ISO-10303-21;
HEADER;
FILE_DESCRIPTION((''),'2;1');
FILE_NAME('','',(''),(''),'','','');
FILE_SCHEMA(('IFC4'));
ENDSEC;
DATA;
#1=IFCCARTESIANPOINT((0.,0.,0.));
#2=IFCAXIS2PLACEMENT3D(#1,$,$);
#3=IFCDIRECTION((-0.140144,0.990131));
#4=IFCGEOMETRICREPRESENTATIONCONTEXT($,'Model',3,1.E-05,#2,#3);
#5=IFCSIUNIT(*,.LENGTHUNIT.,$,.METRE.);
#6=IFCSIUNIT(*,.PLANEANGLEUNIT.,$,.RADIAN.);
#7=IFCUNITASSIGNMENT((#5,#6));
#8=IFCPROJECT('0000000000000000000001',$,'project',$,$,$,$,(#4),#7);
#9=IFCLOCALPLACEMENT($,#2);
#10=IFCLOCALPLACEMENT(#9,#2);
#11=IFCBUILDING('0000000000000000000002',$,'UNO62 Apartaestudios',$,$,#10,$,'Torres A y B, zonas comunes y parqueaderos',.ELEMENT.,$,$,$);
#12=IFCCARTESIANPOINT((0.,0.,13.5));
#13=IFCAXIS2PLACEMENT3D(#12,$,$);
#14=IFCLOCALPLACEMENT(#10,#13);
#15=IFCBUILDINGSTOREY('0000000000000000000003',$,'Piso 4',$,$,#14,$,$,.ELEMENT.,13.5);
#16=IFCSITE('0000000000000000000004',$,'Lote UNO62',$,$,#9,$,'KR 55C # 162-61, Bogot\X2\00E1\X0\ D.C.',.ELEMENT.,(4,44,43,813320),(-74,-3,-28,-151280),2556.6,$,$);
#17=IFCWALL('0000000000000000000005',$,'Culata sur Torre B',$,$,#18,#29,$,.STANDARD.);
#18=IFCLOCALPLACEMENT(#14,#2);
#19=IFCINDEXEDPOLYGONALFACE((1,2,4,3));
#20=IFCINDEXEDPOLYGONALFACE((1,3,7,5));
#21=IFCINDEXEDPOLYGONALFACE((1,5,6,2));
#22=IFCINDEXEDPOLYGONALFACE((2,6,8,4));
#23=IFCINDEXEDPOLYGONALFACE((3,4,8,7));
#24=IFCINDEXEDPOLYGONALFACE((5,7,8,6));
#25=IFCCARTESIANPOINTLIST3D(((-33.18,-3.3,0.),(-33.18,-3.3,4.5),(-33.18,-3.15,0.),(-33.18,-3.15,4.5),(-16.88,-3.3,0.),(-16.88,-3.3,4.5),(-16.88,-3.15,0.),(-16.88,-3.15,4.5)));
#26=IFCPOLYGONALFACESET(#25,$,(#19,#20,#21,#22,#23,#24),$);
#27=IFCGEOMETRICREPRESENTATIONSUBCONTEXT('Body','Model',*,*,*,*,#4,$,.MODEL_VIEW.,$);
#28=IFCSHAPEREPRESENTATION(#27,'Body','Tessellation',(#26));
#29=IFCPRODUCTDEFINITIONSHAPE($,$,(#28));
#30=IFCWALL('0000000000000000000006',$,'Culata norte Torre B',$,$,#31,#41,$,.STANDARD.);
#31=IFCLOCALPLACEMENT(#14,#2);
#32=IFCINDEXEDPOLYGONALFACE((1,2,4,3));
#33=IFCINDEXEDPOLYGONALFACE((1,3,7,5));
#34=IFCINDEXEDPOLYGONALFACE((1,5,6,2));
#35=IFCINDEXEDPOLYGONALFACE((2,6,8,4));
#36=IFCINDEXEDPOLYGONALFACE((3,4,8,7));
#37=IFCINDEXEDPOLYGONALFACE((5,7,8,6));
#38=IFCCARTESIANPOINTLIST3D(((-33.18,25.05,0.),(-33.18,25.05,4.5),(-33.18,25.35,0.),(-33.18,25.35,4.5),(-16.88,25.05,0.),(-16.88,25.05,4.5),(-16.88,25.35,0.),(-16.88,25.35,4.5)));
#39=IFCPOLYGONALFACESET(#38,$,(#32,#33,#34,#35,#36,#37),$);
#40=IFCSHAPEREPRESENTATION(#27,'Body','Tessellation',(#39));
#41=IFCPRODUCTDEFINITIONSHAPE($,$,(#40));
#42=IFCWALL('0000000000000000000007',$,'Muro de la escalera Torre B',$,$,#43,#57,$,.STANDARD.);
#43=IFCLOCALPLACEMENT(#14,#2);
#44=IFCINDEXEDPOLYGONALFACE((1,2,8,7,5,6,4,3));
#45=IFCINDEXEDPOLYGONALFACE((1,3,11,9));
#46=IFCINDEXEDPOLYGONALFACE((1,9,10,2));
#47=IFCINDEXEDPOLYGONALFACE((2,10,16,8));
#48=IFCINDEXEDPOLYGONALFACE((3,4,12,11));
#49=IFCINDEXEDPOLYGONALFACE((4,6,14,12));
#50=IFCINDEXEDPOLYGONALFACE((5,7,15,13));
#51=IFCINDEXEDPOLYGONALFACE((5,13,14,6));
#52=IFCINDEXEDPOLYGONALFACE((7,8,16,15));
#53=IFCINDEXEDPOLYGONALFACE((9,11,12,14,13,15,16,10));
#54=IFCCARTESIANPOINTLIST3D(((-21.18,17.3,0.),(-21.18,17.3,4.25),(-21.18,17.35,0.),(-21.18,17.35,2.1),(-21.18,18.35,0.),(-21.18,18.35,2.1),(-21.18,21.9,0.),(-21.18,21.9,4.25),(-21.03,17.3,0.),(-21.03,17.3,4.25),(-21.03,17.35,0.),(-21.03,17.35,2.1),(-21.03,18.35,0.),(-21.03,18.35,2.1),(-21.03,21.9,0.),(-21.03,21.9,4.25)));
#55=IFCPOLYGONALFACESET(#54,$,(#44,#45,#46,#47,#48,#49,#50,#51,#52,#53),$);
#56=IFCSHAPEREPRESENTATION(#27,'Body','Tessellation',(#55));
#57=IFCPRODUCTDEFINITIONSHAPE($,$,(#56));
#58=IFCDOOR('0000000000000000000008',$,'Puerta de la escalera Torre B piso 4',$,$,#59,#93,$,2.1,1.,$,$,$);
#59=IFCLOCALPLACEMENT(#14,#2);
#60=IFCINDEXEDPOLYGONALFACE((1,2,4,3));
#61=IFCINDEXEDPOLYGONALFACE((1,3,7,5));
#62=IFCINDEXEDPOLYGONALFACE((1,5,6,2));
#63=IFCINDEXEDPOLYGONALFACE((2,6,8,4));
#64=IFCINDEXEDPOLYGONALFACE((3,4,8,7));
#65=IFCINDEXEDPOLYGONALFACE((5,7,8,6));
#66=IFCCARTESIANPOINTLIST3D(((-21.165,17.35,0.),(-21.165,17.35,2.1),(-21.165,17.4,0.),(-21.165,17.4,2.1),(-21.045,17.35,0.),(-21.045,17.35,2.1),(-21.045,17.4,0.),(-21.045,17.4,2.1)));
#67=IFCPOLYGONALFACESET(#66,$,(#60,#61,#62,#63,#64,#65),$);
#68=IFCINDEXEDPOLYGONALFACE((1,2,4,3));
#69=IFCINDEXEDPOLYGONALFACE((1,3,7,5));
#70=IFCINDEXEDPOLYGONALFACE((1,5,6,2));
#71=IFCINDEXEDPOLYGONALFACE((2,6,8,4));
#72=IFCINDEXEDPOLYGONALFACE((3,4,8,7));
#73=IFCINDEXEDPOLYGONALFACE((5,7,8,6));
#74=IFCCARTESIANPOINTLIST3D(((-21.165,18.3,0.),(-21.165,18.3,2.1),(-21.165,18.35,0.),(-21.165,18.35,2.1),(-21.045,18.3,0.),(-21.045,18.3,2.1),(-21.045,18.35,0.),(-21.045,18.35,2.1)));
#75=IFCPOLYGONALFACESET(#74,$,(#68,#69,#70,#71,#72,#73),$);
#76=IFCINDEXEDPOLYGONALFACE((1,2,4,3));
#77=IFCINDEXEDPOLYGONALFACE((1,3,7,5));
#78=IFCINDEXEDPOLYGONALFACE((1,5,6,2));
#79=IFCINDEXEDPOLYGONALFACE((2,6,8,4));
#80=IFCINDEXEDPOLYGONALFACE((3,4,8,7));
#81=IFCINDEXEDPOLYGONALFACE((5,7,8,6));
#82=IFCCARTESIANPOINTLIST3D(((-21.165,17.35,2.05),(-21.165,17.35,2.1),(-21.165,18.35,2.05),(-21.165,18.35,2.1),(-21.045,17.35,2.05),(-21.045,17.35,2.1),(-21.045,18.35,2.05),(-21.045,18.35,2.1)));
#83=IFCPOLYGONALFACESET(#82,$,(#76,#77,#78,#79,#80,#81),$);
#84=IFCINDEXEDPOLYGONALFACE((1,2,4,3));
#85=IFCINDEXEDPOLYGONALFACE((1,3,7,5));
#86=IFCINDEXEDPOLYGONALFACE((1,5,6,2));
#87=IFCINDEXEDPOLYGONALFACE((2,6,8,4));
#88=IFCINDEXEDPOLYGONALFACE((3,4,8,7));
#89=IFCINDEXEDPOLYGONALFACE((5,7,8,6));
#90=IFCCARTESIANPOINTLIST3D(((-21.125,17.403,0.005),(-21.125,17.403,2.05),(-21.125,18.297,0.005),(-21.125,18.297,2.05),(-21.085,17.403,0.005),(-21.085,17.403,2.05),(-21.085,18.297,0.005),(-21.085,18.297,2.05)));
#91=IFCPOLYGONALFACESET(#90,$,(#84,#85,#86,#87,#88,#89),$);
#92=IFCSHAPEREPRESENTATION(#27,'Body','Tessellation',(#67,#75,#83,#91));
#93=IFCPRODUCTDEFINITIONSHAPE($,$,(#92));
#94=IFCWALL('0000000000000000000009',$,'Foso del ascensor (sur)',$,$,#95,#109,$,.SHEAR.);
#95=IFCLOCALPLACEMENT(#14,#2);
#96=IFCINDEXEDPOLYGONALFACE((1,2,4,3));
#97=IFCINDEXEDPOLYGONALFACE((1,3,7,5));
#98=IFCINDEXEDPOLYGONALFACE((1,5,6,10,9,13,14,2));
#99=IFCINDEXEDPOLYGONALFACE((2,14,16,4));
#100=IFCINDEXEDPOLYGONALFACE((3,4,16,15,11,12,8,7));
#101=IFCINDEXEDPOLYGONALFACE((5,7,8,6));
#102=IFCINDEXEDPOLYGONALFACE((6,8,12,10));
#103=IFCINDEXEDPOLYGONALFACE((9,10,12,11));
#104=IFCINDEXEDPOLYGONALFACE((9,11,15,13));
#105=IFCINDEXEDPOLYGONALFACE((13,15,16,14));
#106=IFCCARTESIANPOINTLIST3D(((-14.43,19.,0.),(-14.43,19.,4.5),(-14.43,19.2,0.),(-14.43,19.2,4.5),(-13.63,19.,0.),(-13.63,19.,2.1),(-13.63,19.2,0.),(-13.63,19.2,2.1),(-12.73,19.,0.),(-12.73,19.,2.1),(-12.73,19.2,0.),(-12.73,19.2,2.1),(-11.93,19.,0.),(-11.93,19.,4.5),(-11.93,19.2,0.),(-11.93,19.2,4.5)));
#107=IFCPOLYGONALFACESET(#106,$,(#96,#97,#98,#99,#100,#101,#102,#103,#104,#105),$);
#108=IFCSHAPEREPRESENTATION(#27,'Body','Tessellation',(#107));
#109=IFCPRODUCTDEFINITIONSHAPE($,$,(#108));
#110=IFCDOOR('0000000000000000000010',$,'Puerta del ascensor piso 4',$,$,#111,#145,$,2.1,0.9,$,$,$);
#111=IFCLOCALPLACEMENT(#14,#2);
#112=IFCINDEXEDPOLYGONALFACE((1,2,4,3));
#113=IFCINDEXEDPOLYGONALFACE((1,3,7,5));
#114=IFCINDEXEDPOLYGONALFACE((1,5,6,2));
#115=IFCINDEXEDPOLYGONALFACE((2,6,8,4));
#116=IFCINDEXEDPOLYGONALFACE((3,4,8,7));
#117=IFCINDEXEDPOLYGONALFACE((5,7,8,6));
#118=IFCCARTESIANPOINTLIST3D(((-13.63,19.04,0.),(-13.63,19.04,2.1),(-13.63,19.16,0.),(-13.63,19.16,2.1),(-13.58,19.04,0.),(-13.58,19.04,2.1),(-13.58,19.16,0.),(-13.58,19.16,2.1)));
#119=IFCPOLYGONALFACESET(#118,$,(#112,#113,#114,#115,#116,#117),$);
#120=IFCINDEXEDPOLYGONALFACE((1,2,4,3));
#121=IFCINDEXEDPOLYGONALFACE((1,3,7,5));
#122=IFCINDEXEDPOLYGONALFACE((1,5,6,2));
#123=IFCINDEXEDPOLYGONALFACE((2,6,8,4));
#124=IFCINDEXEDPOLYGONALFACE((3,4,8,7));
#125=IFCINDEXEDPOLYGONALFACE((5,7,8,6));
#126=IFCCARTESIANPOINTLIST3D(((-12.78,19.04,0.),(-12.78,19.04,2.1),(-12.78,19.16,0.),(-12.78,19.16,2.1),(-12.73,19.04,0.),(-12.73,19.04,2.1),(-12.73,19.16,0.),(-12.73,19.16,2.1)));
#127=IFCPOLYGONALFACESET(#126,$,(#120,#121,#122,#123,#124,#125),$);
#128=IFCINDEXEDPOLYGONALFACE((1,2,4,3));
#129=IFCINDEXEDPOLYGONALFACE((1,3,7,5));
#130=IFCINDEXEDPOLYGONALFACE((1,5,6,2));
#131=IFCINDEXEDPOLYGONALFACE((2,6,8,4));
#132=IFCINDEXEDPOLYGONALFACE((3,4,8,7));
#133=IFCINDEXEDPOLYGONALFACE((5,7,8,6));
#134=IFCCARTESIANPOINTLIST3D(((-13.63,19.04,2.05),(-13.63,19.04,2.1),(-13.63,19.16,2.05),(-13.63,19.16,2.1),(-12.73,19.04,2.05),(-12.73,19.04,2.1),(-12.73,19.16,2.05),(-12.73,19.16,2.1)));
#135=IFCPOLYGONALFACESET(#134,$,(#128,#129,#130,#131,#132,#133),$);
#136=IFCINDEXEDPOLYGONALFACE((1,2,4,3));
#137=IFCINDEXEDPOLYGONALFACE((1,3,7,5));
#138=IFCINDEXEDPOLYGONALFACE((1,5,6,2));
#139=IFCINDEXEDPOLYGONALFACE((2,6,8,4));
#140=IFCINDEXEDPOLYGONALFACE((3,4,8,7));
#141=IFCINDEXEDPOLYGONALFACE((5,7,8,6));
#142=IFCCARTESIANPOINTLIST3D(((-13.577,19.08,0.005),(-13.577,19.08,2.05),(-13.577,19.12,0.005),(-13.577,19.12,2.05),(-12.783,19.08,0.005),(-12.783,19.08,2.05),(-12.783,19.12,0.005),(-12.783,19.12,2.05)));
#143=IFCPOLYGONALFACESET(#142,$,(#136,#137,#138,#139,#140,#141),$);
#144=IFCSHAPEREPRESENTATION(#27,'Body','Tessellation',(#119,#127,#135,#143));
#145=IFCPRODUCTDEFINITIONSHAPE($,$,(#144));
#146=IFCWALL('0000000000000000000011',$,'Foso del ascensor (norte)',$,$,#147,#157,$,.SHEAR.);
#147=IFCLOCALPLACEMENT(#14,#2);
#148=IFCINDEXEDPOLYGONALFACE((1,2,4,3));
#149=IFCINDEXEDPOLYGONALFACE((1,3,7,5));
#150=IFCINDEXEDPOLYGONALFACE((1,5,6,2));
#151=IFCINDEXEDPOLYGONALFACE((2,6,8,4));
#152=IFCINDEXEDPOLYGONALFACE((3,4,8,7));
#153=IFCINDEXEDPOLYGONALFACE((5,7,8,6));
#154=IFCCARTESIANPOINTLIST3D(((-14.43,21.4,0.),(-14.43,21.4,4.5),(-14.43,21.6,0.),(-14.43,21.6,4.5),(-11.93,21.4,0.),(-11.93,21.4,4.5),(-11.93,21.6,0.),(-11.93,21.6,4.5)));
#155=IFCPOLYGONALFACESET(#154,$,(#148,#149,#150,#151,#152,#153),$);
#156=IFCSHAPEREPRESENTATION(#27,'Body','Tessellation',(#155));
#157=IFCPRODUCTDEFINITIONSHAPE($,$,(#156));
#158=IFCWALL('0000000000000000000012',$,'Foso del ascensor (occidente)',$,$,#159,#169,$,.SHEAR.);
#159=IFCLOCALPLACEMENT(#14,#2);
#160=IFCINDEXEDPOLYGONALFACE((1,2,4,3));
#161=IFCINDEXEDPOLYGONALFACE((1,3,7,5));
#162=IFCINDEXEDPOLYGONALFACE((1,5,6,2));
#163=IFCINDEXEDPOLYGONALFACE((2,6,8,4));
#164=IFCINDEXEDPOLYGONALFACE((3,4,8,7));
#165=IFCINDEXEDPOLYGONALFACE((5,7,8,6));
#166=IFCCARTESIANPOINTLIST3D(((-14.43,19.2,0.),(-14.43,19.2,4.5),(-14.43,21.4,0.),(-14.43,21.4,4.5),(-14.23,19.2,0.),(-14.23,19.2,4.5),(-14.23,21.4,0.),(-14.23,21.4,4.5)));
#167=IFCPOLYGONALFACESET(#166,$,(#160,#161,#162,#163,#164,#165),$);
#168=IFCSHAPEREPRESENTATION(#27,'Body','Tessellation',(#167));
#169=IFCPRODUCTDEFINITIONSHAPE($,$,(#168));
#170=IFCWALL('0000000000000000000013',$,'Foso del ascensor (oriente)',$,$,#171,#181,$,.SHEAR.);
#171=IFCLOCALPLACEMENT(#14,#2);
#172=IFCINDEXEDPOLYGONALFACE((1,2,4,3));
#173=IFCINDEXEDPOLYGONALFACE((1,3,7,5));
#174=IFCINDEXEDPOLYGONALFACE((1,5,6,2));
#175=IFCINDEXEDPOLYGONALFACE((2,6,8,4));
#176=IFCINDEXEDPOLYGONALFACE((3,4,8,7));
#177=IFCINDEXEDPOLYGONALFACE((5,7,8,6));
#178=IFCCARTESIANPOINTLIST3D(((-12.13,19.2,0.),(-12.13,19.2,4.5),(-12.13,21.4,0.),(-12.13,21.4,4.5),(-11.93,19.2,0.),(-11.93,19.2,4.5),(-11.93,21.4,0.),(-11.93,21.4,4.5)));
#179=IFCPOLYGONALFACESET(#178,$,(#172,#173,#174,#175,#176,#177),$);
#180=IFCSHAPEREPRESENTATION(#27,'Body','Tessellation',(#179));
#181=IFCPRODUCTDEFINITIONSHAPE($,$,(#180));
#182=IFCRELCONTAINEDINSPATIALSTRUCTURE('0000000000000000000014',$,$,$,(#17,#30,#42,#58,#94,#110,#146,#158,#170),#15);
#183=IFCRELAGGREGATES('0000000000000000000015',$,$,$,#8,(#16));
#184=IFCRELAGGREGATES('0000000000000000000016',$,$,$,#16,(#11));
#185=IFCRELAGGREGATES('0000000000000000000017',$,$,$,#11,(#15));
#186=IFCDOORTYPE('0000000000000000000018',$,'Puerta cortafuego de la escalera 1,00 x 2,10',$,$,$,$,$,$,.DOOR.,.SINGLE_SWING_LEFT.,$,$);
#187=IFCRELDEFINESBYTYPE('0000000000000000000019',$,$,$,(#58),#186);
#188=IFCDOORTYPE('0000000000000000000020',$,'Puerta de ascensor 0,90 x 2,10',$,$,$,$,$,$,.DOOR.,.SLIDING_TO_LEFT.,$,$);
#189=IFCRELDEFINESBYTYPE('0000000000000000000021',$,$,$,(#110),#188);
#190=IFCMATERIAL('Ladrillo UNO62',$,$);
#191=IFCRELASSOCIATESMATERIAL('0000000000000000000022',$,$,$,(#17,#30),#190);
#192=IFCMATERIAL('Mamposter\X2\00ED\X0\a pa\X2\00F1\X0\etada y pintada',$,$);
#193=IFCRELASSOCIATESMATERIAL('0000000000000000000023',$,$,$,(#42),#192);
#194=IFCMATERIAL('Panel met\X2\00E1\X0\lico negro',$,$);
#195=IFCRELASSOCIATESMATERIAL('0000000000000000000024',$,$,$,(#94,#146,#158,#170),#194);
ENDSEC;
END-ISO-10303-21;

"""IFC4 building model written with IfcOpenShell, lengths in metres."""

from ifc_helpers import new_model, si_unit, direction, frame, frame_2d, origin, place, context, subcontext, project, spatial, rectangle, extrude, source, transform, mapped, material, type_object, type_shapes, element, fill, save


model = new_model("IFC4")

# Units and contexts
model_context = context("Model", 3, precision=1e-05, world=origin(), true_north=direction((-0.140144, 0.990131)))
body_context = subcontext(model_context, "Body", "Model", "MODEL_VIEW")
ifc_project = project(units=[si_unit("LENGTHUNIT", "METRE"), si_unit("PLANEANGLEUNIT", "RADIAN")], contexts=[model_context])

# Site, building, storey
site_placement = place(None, origin())
site = spatial("IfcSite", under=ifc_project, at=site_placement, Name="Lote UNO62", LongName="KR 55C # 162-61, Bogotá D.C.", CompositionType="ELEMENT", RefLatitude=(4, 44, 43, 813320), RefLongitude=(-74, -3, -28, -151280), RefElevation=2556.6)
building_placement = place(site_placement, origin())
building = spatial("IfcBuilding", under=site, at=building_placement, Name="UNO62 Apartaestudios", LongName="Torres A y B, zonas comunes y parqueaderos", CompositionType="ELEMENT")
storey_placement = place(building_placement, frame((0.0, 0.0, 13.5)))
storey = spatial("IfcBuildingStorey", under=building, at=storey_placement, Name="Piso 4", CompositionType="ELEMENT", Elevation=13.5)

# Shared definitions
ifc_material_1 = material(Name="Ladrillo UNO62")

# Shared definitions
ifc_material_2 = material(Name="Mampostería pañetada y pintada")

# Walls
wall_1_placement = place(storey_placement, origin())
element("IfcWall", 1, at=wall_1_placement, inside=storey, material=ifc_material_1, Name="Culata sur Torre B", PredefinedType="STANDARD", context=body_context, shape_type="SweptSolid", body=[
    extrude(rectangle(XDim=16.3, YDim=0.15, at=frame_2d((-25.03, -3.225))), origin(), (0.0, 0.0, 1.0), 4.5),
])
wall_2_placement = place(storey_placement, origin())
element("IfcWall", 2, at=wall_2_placement, inside=storey, material=ifc_material_1, Name="Culata norte Torre B", PredefinedType="STANDARD", context=body_context, shape_type="SweptSolid", body=[
    extrude(rectangle(XDim=16.3, YDim=0.3, at=frame_2d((-25.03, 25.2))), origin(), (0.0, 0.0, 1.0), 4.5),
])

# Walls, openings, doors
wall_3_placement = place(storey_placement, origin())
wall_3 = element("IfcWall", 3, at=wall_3_placement, inside=storey, material=ifc_material_2, Name="Muro de la escalera Torre B", PredefinedType="STANDARD", context=body_context, shape_type="SweptSolid", body=[
    extrude(rectangle(XDim=0.15, YDim=4.6, at=frame_2d((-21.105, 19.6))), origin(), (0.0, 0.0, 1.0), 4.25),
])
opening_1_placement = place(wall_3_placement, origin())
opening_1 = element("IfcOpeningElement", 4, at=opening_1_placement, cuts=wall_3, PredefinedType="OPENING", context=body_context, shape_type="SweptSolid", body=[
    extrude(rectangle(XDim=0.25, YDim=1.0, at=frame_2d((-21.105, 17.85))), origin(), (0.0, 0.0, 1.0), 2.1),
])
door_type_1 = type_object("IfcDoorType", Name="Puerta cortafuego de la escalera 1,00 x 2,10", OperationType="SINGLE_SWING_LEFT", PredefinedType="DOOR")
shared_shape_1 = source(origin(), body_context, "Body", "SweptSolid", [
    extrude(rectangle(XDim=0.05, YDim=0.12, at=frame_2d((0.025, 0.0))), origin(), (0.0, 0.0, 1.0), 2.1),
    extrude(rectangle(XDim=0.05, YDim=0.12, at=frame_2d((0.975, 0.0))), origin(), (0.0, 0.0, 1.0), 2.1),
    extrude(rectangle(XDim=1.0, YDim=0.12, at=frame_2d((0.5, 0.0))), frame((0.0, 0.0, 2.05)), (0.0, 0.0, 1.0), 0.05),
    extrude(rectangle(XDim=0.894, YDim=0.04, at=frame_2d((0.5, 0.0))), frame((0.0, 0.0, 0.005)), (0.0, 0.0, 1.0), 2.045),
])
type_shapes(door_type_1, [shared_shape_1])
door_1_placement = place(storey_placement, frame((-21.105, 17.35, 0.0), z_axis=(0.0, 0.0, 1.0), x_axis=(0.0, 1.0, 0.0)))
door_1 = element("IfcDoor", 5, at=door_1_placement, inside=storey, type_object=door_type_1, Name="Puerta de la escalera Torre B piso 4", OverallHeight=2.1, OverallWidth=1.0, context=body_context, shape_type="MappedRepresentation", body=[
    mapped(shared_shape_1, transform((0.0, 0.0, 0.0))),
])
fill(opening_1, door_1)
ifc_material_3 = material(Name="Panel metálico negro")
wall_4_placement = place(storey_placement, origin())
wall_4 = element("IfcWall", 6, at=wall_4_placement, inside=storey, material=ifc_material_3, Name="Foso del ascensor (sur)", PredefinedType="SHEAR", context=body_context, shape_type="SweptSolid", body=[
    extrude(rectangle(XDim=2.5, YDim=0.2, at=frame_2d((-13.18, 19.1))), origin(), (0.0, 0.0, 1.0), 4.5),
])
opening_2_placement = place(wall_4_placement, origin())
opening_2 = element("IfcOpeningElement", 7, at=opening_2_placement, cuts=wall_4, PredefinedType="OPENING", context=body_context, shape_type="SweptSolid", body=[
    extrude(rectangle(XDim=0.9, YDim=0.3, at=frame_2d((-13.18, 19.1))), origin(), (0.0, 0.0, 1.0), 2.1),
])
door_type_2 = type_object("IfcDoorType", Name="Puerta de ascensor 0,90 x 2,10", OperationType="SLIDING_TO_LEFT", PredefinedType="DOOR")
shared_shape_2 = source(origin(), body_context, "Body", "SweptSolid", [
    extrude(rectangle(XDim=0.05, YDim=0.12, at=frame_2d((0.025, 0.0))), origin(), (0.0, 0.0, 1.0), 2.1),
    extrude(rectangle(XDim=0.05, YDim=0.12, at=frame_2d((0.875, 0.0))), origin(), (0.0, 0.0, 1.0), 2.1),
    extrude(rectangle(XDim=0.9, YDim=0.12, at=frame_2d((0.45, 0.0))), frame((0.0, 0.0, 2.05)), (0.0, 0.0, 1.0), 0.05),
    extrude(rectangle(XDim=0.794, YDim=0.04, at=frame_2d((0.45, 0.0))), frame((0.0, 0.0, 0.005)), (0.0, 0.0, 1.0), 2.045),
])
type_shapes(door_type_2, [shared_shape_2])
door_2_placement = place(storey_placement, frame((-13.63, 19.1, 0.0), z_axis=(0.0, 0.0, 1.0), x_axis=(1.0, 0.0, 0.0)))
door_2 = element("IfcDoor", 8, at=door_2_placement, inside=storey, type_object=door_type_2, Name="Puerta del ascensor piso 4", OverallHeight=2.1, OverallWidth=0.9, context=body_context, shape_type="MappedRepresentation", body=[
    mapped(shared_shape_2, transform((0.0, 0.0, 0.0))),
])
fill(opening_2, door_2)

# Walls
wall_5_placement = place(storey_placement, origin())
element("IfcWall", 9, at=wall_5_placement, inside=storey, material=ifc_material_3, Name="Foso del ascensor (norte)", PredefinedType="SHEAR", context=body_context, shape_type="SweptSolid", body=[
    extrude(rectangle(XDim=2.5, YDim=0.2, at=frame_2d((-13.18, 21.5))), origin(), (0.0, 0.0, 1.0), 4.5),
])
wall_6_placement = place(storey_placement, origin())
element("IfcWall", 10, at=wall_6_placement, inside=storey, material=ifc_material_3, Name="Foso del ascensor (occidente)", PredefinedType="SHEAR", context=body_context, shape_type="SweptSolid", body=[
    extrude(rectangle(XDim=0.2, YDim=2.2, at=frame_2d((-14.33, 20.3))), origin(), (0.0, 0.0, 1.0), 4.5),
])
wall_7_placement = place(storey_placement, origin())
element("IfcWall", 11, at=wall_7_placement, inside=storey, material=ifc_material_3, Name="Foso del ascensor (oriente)", PredefinedType="SHEAR", context=body_context, shape_type="SweptSolid", body=[
    extrude(rectangle(XDim=0.2, YDim=2.2, at=frame_2d((-12.03, 20.3))), origin(), (0.0, 0.0, 1.0), 4.5),
])

save(model, "model.ifc")
